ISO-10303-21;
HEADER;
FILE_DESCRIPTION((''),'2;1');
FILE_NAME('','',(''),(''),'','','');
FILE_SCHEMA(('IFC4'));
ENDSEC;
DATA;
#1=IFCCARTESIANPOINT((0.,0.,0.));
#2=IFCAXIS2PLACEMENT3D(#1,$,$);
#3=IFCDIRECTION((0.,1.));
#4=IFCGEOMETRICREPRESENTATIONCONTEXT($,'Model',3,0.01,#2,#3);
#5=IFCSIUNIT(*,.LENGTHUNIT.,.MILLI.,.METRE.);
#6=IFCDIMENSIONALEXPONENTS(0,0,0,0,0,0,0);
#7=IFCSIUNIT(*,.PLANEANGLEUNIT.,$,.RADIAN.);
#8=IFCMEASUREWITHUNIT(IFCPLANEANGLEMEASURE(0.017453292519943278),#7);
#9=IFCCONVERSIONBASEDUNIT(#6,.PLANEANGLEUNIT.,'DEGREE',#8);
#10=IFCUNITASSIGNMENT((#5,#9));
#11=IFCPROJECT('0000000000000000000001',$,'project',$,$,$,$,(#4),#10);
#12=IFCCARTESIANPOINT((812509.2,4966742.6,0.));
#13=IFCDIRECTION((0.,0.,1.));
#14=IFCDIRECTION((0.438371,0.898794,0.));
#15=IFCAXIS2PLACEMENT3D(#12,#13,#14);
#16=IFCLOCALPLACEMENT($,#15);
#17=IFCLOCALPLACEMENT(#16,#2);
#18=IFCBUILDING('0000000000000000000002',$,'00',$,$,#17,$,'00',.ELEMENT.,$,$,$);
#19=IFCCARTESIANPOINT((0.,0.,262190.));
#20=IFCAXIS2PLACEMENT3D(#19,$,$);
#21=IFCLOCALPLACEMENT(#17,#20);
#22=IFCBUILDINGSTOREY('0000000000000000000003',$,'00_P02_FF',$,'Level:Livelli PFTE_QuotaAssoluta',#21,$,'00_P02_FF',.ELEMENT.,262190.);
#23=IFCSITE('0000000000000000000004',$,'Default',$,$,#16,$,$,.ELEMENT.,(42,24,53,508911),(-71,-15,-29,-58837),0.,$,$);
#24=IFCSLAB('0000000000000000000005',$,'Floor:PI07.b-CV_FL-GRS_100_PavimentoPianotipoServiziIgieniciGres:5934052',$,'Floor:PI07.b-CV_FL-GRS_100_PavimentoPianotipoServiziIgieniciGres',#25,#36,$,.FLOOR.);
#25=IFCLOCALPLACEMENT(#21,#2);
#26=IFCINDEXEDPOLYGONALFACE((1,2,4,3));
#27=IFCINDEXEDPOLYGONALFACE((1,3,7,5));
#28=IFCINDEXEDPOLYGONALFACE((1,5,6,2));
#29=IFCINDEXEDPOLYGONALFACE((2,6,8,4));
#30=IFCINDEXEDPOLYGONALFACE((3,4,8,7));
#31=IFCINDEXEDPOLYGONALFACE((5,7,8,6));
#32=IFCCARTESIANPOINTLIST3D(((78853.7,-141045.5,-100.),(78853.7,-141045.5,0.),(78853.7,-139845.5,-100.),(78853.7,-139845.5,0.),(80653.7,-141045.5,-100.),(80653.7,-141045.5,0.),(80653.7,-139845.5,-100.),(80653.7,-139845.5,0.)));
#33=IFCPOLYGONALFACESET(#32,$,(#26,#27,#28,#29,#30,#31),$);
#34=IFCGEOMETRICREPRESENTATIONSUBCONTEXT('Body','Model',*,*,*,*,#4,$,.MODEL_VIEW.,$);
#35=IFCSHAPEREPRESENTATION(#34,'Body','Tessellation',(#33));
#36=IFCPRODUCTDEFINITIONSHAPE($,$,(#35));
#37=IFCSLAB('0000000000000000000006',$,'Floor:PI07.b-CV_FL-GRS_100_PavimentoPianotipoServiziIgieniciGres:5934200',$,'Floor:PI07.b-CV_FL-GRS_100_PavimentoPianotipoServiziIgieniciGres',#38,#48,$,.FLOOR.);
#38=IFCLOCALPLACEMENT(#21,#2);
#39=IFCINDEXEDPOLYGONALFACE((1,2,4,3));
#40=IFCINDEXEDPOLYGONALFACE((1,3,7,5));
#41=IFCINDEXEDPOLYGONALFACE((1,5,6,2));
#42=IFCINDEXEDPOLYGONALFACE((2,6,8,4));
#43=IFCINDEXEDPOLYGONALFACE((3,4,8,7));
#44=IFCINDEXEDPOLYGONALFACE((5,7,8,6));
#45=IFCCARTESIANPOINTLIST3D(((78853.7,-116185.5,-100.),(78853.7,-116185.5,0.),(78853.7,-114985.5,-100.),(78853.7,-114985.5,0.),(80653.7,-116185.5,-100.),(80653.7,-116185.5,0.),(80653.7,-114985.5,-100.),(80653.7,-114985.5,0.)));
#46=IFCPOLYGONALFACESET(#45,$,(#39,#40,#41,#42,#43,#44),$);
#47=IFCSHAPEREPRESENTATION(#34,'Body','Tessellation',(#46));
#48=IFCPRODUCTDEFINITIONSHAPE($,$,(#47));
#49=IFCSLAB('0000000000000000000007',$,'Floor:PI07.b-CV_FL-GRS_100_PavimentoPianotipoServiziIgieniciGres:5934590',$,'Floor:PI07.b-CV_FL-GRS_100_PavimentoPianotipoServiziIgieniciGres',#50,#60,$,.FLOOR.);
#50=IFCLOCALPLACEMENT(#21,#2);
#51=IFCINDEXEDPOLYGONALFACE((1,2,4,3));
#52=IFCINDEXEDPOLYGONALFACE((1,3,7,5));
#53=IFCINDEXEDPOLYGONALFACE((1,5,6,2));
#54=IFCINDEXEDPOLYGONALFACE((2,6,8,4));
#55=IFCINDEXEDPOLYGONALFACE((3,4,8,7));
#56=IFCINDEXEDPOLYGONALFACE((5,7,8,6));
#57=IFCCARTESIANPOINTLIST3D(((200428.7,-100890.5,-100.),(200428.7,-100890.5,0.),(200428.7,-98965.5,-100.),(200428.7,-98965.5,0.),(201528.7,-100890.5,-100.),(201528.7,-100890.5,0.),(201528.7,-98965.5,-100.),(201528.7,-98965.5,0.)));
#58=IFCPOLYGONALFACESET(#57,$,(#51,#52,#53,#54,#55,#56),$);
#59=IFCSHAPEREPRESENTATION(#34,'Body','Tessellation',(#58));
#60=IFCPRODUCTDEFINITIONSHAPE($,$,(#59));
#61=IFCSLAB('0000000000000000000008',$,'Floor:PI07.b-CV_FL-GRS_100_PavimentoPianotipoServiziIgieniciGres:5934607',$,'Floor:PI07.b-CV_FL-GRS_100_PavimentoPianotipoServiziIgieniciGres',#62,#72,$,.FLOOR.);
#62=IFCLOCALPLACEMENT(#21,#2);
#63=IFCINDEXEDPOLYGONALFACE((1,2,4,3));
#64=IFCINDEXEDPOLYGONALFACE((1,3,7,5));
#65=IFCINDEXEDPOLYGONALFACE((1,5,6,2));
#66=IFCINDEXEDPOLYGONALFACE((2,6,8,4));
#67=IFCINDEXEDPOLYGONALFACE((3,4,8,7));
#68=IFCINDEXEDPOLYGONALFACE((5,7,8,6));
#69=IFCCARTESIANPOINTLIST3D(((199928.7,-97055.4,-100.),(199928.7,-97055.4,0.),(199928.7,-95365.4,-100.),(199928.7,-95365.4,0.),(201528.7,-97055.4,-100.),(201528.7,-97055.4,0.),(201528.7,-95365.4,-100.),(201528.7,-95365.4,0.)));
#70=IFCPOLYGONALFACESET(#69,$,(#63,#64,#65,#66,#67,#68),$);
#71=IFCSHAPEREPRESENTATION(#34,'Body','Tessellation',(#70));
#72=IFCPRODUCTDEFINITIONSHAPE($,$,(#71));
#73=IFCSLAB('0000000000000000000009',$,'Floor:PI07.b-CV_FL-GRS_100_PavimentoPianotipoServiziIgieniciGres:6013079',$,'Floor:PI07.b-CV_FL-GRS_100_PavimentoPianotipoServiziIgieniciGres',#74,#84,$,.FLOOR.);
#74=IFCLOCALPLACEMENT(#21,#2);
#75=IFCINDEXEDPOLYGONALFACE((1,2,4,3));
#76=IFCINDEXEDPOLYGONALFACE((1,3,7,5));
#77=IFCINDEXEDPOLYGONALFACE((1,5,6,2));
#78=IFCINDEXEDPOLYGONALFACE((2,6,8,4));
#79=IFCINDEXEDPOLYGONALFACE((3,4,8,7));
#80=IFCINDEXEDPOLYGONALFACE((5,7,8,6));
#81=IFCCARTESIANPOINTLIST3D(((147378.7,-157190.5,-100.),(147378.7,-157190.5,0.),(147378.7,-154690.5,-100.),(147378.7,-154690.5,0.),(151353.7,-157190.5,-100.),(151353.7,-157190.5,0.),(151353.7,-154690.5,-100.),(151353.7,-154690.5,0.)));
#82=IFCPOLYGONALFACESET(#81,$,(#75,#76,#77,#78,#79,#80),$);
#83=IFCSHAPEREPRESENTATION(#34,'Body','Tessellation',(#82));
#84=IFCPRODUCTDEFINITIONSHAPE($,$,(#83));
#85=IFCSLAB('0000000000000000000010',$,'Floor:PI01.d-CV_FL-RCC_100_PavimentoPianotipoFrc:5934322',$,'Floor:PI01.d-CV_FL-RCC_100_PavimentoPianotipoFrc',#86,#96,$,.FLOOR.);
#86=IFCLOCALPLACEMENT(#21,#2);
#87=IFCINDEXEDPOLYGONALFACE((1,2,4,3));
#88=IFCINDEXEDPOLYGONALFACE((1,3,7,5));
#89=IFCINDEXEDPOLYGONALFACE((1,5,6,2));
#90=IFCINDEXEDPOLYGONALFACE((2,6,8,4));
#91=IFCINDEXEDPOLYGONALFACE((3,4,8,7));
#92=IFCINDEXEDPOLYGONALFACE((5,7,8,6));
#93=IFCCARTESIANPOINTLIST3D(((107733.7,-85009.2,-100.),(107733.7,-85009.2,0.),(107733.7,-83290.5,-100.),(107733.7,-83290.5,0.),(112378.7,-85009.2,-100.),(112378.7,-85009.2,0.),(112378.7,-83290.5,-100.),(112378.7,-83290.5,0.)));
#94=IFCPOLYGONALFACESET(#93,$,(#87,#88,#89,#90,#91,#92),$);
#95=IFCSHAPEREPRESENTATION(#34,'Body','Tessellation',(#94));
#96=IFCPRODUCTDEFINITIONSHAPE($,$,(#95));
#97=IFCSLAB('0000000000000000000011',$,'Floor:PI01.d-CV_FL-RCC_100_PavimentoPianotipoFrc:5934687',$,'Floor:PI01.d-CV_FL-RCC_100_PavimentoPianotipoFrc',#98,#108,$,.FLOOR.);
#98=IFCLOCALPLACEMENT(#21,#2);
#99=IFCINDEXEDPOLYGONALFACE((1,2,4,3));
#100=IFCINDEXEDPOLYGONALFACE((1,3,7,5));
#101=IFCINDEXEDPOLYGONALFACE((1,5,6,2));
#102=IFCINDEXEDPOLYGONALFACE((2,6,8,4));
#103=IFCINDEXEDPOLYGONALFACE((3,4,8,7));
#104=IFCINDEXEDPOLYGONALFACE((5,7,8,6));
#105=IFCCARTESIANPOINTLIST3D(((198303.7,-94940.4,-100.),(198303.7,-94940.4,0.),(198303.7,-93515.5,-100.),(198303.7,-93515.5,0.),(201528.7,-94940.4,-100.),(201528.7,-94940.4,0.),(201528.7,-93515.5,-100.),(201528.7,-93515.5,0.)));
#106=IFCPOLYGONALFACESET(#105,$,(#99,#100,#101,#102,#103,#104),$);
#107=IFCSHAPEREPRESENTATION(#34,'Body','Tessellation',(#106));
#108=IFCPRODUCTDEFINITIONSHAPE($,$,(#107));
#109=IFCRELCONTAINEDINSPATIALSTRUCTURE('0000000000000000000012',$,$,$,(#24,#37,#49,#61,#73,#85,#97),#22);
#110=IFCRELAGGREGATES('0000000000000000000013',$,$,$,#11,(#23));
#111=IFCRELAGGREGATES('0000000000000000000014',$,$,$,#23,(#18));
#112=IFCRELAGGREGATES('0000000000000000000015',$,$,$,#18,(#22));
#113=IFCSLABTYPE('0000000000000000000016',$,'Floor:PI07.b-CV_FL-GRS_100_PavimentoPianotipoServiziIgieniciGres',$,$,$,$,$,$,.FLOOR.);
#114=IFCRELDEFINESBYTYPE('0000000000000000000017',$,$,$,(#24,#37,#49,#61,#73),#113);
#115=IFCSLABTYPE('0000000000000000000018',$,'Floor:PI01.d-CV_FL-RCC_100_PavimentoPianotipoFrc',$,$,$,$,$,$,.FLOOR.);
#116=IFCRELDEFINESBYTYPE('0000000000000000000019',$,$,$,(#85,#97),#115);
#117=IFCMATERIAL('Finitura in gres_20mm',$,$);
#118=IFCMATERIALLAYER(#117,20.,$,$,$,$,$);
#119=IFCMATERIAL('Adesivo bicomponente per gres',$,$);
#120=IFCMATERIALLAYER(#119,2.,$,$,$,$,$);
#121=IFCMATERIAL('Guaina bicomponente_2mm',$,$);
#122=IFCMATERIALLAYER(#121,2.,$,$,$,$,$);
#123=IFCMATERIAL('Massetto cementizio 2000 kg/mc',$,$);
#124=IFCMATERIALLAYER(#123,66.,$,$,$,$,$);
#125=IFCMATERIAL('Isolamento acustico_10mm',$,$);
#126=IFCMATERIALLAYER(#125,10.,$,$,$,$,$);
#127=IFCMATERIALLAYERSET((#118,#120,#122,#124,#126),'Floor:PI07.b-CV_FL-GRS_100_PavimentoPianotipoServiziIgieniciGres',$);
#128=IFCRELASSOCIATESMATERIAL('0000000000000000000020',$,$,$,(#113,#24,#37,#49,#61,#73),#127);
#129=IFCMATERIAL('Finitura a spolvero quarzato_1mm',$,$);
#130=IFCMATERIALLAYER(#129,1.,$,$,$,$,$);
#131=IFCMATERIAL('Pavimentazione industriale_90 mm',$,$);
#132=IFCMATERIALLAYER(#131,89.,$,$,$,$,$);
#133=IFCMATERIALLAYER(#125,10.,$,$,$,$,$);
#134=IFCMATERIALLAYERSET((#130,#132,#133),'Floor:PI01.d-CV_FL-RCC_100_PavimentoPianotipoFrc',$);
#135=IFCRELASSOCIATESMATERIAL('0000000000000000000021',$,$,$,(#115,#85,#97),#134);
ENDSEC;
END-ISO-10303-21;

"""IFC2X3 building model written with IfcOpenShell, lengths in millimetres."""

from ifc_helpers import new_model, entity, si_unit, converted_unit, direction, frame, frame_2d, origin, origin_2d_with_axis, place, context, subcontext, project, spatial, rectangle, extrude, material, layer, layer_set, layer_usage, type_object, element, save


model = new_model("IFC2X3")

# Units and contexts
model_context = context("Model", 3, precision=0.01, world=origin(), true_north=direction((0.0, 1.0)))
body_context = subcontext(model_context, "Body", "Model", "MODEL_VIEW")
ifc_project = project(units=[si_unit("LENGTHUNIT", "METRE", prefix="MILLI"), converted_unit("PLANEANGLEUNIT", "DEGREE", entity("IfcPlaneAngleMeasure", 0.017453292519943278), si_unit("PLANEANGLEUNIT", "RADIAN"), dimensions=[0, 0, 0, 0, 0, 0, 0])], contexts=[model_context])

# Site, building, storey
site_placement = place(None, frame((812509.2, 4966742.6, 0.0), z_axis=(0.0, 0.0, 1.0), x_axis=(0.438371, 0.898794, 0.0)))
site = spatial("IfcSite", under=ifc_project, at=site_placement, Name="Default", CompositionType="ELEMENT", RefLatitude=(42, 24, 53, 508911), RefLongitude=(-71, -15, -29, -58837), RefElevation=0.0)
building_placement = place(site_placement, origin())
building = spatial("IfcBuilding", under=site, at=building_placement, Name="00", LongName="00", CompositionType="ELEMENT")
storey_placement = place(building_placement, frame((0.0, 0.0, 262190.0)))
storey = spatial("IfcBuildingStorey", under=building, at=storey_placement, Name="00_P02_FF", ObjectType="Level:Livelli PFTE_QuotaAssoluta", LongName="00_P02_FF", CompositionType="ELEMENT", Elevation=262190.0)

# Shared definitions
ifc_material_1 = material(Name="Massetto cementizio 2000 kg/mc")
ifc_material_2 = material(Name="Isolamento acustico_10mm")

# Slabs
ifc_material_3 = material(Name="Finitura in gres_20mm")
ifc_layer_1 = layer(ifc_material_3, 20.0)
ifc_material_4 = material(Name="Adesivo bicomponente per gres")
ifc_layer_2 = layer(ifc_material_4, 2.0)
ifc_material_5 = material(Name="Guaina bicomponente_2mm")
ifc_layer_3 = layer(ifc_material_5, 2.0)
ifc_layer_4 = layer(ifc_material_1, 66.0)
ifc_layer_5 = layer(ifc_material_2, 10.0)
ifc_layer_set_1 = layer_set([ifc_layer_1, ifc_layer_2, ifc_layer_3, ifc_layer_4, ifc_layer_5], Name="Floor:PI07.b-CV_FL-GRS_100_PavimentoPianotipoServiziIgieniciGres")
slab_type_1 = type_object("IfcSlabType", Name="Floor:PI07.b-CV_FL-GRS_100_PavimentoPianotipoServiziIgieniciGres", PredefinedType="FLOOR", material=ifc_layer_set_1)
ifc_layer_usage_1 = layer_usage(ifc_layer_set_1, "AXIS3", "POSITIVE", 0.0)
slab_1_placement = place(storey_placement, origin())
element("IfcSlab", 1, at=slab_1_placement, inside=storey, type_object=slab_type_1, material=ifc_layer_usage_1, Name="Floor:PI07.b-CV_FL-GRS_100_PavimentoPianotipoServiziIgieniciGres:5934052", ObjectType="Floor:PI07.b-CV_FL-GRS_100_PavimentoPianotipoServiziIgieniciGres", PredefinedType="FLOOR", context=body_context, shape_type="SweptSolid", body=[
    extrude(rectangle(XDim=1200.0, YDim=1800.0, at=frame_2d((0.0, 0.0), x_axis=(1.0, 0.0))), frame((79753.7, -140445.5, 0.0), z_axis=(0.0, 0.0, -1.0), x_axis=(0.0, 1.0, 0.0)), (0.0, 0.0, 1.0), 100.0),
])
ifc_layer_usage_2 = layer_usage(ifc_layer_set_1, "AXIS3", "POSITIVE", 0.0)
slab_2_placement = place(storey_placement, origin())
element("IfcSlab", 2, at=slab_2_placement, inside=storey, type_object=slab_type_1, material=ifc_layer_usage_2, Name="Floor:PI07.b-CV_FL-GRS_100_PavimentoPianotipoServiziIgieniciGres:5934200", ObjectType="Floor:PI07.b-CV_FL-GRS_100_PavimentoPianotipoServiziIgieniciGres", PredefinedType="FLOOR", context=body_context, shape_type="SweptSolid", body=[
    extrude(rectangle(XDim=1200.0, YDim=1800.0, at=frame_2d((0.0, 0.0), x_axis=(1.0, 0.0))), frame((79753.7, -115585.5, 0.0), z_axis=(0.0, 0.0, -1.0), x_axis=(0.0, 1.0, 0.0)), (0.0, 0.0, 1.0), 100.0),
])
ifc_layer_usage_3 = layer_usage(ifc_layer_set_1, "AXIS3", "POSITIVE", 0.0)
slab_3_placement = place(storey_placement, origin())
element("IfcSlab", 3, at=slab_3_placement, inside=storey, type_object=slab_type_1, material=ifc_layer_usage_3, Name="Floor:PI07.b-CV_FL-GRS_100_PavimentoPianotipoServiziIgieniciGres:5934590", ObjectType="Floor:PI07.b-CV_FL-GRS_100_PavimentoPianotipoServiziIgieniciGres", PredefinedType="FLOOR", context=body_context, shape_type="SweptSolid", body=[
    extrude(rectangle(XDim=1925.0, YDim=1100.0, at=frame_2d((0.0, 0.0), x_axis=(1.0, 0.0))), frame((200978.7, -99928.0, 0.0), z_axis=(0.0, 0.0, -1.0), x_axis=(0.0, 1.0, 0.0)), (0.0, 0.0, 1.0), 100.0),
])
ifc_layer_usage_4 = layer_usage(ifc_layer_set_1, "AXIS3", "POSITIVE", 0.0)
slab_4_placement = place(storey_placement, origin())
element("IfcSlab", 4, at=slab_4_placement, inside=storey, type_object=slab_type_1, material=ifc_layer_usage_4, Name="Floor:PI07.b-CV_FL-GRS_100_PavimentoPianotipoServiziIgieniciGres:5934607", ObjectType="Floor:PI07.b-CV_FL-GRS_100_PavimentoPianotipoServiziIgieniciGres", PredefinedType="FLOOR", context=body_context, shape_type="SweptSolid", body=[
    extrude(rectangle(XDim=1690.0, YDim=1600.0, at=frame_2d((0.0, 0.0), x_axis=(1.0, 0.0))), frame((200728.7, -96210.4, 0.0), z_axis=(0.0, 0.0, -1.0), x_axis=(0.0, 1.0, 0.0)), (0.0, 0.0, 1.0), 100.0),
])
ifc_layer_usage_5 = layer_usage(ifc_layer_set_1, "AXIS3", "POSITIVE", 0.0)
slab_5_placement = place(storey_placement, origin())
element("IfcSlab", 5, at=slab_5_placement, inside=storey, type_object=slab_type_1, material=ifc_layer_usage_5, Name="Floor:PI07.b-CV_FL-GRS_100_PavimentoPianotipoServiziIgieniciGres:6013079", ObjectType="Floor:PI07.b-CV_FL-GRS_100_PavimentoPianotipoServiziIgieniciGres", PredefinedType="FLOOR", context=body_context, shape_type="SweptSolid", body=[
    extrude(rectangle(XDim=2500.0, YDim=3975.0, at=origin_2d_with_axis()), frame((149366.2, -155940.5, 0.0), z_axis=(0.0, 0.0, -1.0), x_axis=(0.0, 1.0, 0.0)), (0.0, 0.0, 1.0), 100.0),
])
ifc_material_6 = material(Name="Finitura a spolvero quarzato_1mm")
ifc_layer_6 = layer(ifc_material_6, 1.0)
ifc_material_7 = material(Name="Pavimentazione industriale_90 mm")
ifc_layer_7 = layer(ifc_material_7, 89.0)
ifc_layer_8 = layer(ifc_material_2, 10.0)
ifc_layer_set_2 = layer_set([ifc_layer_6, ifc_layer_7, ifc_layer_8], Name="Floor:PI01.d-CV_FL-RCC_100_PavimentoPianotipoFrc")
slab_type_2 = type_object("IfcSlabType", Name="Floor:PI01.d-CV_FL-RCC_100_PavimentoPianotipoFrc", PredefinedType="FLOOR", material=ifc_layer_set_2)
ifc_layer_usage_6 = layer_usage(ifc_layer_set_2, "AXIS3", "POSITIVE", 0.0)
slab_6_placement = place(storey_placement, origin())
element("IfcSlab", 6, at=slab_6_placement, inside=storey, type_object=slab_type_2, material=ifc_layer_usage_6, Name="Floor:PI01.d-CV_FL-RCC_100_PavimentoPianotipoFrc:5934322", ObjectType="Floor:PI01.d-CV_FL-RCC_100_PavimentoPianotipoFrc", PredefinedType="FLOOR", context=body_context, shape_type="SweptSolid", body=[
    extrude(rectangle(XDim=1718.7, YDim=4645.0, at=frame_2d((0.0, 0.0), x_axis=(1.0, 0.0))), frame((110056.2, -84149.9, 0.0), z_axis=(0.0, 0.0, -1.0), x_axis=(0.0, 1.0, 0.0)), (0.0, 0.0, 1.0), 100.0),
])
ifc_layer_usage_7 = layer_usage(ifc_layer_set_2, "AXIS3", "POSITIVE", 0.0)
slab_7_placement = place(storey_placement, origin())
element("IfcSlab", 7, at=slab_7_placement, inside=storey, type_object=slab_type_2, material=ifc_layer_usage_7, Name="Floor:PI01.d-CV_FL-RCC_100_PavimentoPianotipoFrc:5934687", ObjectType="Floor:PI01.d-CV_FL-RCC_100_PavimentoPianotipoFrc", PredefinedType="FLOOR", context=body_context, shape_type="SweptSolid", body=[
    extrude(rectangle(XDim=1424.9, YDim=3225.0, at=frame_2d((0.0, 0.0), x_axis=(1.0, 0.0))), frame((199916.2, -94227.9, 0.0), z_axis=(0.0, 0.0, -1.0), x_axis=(0.0, 1.0, 0.0)), (0.0, 0.0, 1.0), 100.0),
])

save(model, "model.ifc")
